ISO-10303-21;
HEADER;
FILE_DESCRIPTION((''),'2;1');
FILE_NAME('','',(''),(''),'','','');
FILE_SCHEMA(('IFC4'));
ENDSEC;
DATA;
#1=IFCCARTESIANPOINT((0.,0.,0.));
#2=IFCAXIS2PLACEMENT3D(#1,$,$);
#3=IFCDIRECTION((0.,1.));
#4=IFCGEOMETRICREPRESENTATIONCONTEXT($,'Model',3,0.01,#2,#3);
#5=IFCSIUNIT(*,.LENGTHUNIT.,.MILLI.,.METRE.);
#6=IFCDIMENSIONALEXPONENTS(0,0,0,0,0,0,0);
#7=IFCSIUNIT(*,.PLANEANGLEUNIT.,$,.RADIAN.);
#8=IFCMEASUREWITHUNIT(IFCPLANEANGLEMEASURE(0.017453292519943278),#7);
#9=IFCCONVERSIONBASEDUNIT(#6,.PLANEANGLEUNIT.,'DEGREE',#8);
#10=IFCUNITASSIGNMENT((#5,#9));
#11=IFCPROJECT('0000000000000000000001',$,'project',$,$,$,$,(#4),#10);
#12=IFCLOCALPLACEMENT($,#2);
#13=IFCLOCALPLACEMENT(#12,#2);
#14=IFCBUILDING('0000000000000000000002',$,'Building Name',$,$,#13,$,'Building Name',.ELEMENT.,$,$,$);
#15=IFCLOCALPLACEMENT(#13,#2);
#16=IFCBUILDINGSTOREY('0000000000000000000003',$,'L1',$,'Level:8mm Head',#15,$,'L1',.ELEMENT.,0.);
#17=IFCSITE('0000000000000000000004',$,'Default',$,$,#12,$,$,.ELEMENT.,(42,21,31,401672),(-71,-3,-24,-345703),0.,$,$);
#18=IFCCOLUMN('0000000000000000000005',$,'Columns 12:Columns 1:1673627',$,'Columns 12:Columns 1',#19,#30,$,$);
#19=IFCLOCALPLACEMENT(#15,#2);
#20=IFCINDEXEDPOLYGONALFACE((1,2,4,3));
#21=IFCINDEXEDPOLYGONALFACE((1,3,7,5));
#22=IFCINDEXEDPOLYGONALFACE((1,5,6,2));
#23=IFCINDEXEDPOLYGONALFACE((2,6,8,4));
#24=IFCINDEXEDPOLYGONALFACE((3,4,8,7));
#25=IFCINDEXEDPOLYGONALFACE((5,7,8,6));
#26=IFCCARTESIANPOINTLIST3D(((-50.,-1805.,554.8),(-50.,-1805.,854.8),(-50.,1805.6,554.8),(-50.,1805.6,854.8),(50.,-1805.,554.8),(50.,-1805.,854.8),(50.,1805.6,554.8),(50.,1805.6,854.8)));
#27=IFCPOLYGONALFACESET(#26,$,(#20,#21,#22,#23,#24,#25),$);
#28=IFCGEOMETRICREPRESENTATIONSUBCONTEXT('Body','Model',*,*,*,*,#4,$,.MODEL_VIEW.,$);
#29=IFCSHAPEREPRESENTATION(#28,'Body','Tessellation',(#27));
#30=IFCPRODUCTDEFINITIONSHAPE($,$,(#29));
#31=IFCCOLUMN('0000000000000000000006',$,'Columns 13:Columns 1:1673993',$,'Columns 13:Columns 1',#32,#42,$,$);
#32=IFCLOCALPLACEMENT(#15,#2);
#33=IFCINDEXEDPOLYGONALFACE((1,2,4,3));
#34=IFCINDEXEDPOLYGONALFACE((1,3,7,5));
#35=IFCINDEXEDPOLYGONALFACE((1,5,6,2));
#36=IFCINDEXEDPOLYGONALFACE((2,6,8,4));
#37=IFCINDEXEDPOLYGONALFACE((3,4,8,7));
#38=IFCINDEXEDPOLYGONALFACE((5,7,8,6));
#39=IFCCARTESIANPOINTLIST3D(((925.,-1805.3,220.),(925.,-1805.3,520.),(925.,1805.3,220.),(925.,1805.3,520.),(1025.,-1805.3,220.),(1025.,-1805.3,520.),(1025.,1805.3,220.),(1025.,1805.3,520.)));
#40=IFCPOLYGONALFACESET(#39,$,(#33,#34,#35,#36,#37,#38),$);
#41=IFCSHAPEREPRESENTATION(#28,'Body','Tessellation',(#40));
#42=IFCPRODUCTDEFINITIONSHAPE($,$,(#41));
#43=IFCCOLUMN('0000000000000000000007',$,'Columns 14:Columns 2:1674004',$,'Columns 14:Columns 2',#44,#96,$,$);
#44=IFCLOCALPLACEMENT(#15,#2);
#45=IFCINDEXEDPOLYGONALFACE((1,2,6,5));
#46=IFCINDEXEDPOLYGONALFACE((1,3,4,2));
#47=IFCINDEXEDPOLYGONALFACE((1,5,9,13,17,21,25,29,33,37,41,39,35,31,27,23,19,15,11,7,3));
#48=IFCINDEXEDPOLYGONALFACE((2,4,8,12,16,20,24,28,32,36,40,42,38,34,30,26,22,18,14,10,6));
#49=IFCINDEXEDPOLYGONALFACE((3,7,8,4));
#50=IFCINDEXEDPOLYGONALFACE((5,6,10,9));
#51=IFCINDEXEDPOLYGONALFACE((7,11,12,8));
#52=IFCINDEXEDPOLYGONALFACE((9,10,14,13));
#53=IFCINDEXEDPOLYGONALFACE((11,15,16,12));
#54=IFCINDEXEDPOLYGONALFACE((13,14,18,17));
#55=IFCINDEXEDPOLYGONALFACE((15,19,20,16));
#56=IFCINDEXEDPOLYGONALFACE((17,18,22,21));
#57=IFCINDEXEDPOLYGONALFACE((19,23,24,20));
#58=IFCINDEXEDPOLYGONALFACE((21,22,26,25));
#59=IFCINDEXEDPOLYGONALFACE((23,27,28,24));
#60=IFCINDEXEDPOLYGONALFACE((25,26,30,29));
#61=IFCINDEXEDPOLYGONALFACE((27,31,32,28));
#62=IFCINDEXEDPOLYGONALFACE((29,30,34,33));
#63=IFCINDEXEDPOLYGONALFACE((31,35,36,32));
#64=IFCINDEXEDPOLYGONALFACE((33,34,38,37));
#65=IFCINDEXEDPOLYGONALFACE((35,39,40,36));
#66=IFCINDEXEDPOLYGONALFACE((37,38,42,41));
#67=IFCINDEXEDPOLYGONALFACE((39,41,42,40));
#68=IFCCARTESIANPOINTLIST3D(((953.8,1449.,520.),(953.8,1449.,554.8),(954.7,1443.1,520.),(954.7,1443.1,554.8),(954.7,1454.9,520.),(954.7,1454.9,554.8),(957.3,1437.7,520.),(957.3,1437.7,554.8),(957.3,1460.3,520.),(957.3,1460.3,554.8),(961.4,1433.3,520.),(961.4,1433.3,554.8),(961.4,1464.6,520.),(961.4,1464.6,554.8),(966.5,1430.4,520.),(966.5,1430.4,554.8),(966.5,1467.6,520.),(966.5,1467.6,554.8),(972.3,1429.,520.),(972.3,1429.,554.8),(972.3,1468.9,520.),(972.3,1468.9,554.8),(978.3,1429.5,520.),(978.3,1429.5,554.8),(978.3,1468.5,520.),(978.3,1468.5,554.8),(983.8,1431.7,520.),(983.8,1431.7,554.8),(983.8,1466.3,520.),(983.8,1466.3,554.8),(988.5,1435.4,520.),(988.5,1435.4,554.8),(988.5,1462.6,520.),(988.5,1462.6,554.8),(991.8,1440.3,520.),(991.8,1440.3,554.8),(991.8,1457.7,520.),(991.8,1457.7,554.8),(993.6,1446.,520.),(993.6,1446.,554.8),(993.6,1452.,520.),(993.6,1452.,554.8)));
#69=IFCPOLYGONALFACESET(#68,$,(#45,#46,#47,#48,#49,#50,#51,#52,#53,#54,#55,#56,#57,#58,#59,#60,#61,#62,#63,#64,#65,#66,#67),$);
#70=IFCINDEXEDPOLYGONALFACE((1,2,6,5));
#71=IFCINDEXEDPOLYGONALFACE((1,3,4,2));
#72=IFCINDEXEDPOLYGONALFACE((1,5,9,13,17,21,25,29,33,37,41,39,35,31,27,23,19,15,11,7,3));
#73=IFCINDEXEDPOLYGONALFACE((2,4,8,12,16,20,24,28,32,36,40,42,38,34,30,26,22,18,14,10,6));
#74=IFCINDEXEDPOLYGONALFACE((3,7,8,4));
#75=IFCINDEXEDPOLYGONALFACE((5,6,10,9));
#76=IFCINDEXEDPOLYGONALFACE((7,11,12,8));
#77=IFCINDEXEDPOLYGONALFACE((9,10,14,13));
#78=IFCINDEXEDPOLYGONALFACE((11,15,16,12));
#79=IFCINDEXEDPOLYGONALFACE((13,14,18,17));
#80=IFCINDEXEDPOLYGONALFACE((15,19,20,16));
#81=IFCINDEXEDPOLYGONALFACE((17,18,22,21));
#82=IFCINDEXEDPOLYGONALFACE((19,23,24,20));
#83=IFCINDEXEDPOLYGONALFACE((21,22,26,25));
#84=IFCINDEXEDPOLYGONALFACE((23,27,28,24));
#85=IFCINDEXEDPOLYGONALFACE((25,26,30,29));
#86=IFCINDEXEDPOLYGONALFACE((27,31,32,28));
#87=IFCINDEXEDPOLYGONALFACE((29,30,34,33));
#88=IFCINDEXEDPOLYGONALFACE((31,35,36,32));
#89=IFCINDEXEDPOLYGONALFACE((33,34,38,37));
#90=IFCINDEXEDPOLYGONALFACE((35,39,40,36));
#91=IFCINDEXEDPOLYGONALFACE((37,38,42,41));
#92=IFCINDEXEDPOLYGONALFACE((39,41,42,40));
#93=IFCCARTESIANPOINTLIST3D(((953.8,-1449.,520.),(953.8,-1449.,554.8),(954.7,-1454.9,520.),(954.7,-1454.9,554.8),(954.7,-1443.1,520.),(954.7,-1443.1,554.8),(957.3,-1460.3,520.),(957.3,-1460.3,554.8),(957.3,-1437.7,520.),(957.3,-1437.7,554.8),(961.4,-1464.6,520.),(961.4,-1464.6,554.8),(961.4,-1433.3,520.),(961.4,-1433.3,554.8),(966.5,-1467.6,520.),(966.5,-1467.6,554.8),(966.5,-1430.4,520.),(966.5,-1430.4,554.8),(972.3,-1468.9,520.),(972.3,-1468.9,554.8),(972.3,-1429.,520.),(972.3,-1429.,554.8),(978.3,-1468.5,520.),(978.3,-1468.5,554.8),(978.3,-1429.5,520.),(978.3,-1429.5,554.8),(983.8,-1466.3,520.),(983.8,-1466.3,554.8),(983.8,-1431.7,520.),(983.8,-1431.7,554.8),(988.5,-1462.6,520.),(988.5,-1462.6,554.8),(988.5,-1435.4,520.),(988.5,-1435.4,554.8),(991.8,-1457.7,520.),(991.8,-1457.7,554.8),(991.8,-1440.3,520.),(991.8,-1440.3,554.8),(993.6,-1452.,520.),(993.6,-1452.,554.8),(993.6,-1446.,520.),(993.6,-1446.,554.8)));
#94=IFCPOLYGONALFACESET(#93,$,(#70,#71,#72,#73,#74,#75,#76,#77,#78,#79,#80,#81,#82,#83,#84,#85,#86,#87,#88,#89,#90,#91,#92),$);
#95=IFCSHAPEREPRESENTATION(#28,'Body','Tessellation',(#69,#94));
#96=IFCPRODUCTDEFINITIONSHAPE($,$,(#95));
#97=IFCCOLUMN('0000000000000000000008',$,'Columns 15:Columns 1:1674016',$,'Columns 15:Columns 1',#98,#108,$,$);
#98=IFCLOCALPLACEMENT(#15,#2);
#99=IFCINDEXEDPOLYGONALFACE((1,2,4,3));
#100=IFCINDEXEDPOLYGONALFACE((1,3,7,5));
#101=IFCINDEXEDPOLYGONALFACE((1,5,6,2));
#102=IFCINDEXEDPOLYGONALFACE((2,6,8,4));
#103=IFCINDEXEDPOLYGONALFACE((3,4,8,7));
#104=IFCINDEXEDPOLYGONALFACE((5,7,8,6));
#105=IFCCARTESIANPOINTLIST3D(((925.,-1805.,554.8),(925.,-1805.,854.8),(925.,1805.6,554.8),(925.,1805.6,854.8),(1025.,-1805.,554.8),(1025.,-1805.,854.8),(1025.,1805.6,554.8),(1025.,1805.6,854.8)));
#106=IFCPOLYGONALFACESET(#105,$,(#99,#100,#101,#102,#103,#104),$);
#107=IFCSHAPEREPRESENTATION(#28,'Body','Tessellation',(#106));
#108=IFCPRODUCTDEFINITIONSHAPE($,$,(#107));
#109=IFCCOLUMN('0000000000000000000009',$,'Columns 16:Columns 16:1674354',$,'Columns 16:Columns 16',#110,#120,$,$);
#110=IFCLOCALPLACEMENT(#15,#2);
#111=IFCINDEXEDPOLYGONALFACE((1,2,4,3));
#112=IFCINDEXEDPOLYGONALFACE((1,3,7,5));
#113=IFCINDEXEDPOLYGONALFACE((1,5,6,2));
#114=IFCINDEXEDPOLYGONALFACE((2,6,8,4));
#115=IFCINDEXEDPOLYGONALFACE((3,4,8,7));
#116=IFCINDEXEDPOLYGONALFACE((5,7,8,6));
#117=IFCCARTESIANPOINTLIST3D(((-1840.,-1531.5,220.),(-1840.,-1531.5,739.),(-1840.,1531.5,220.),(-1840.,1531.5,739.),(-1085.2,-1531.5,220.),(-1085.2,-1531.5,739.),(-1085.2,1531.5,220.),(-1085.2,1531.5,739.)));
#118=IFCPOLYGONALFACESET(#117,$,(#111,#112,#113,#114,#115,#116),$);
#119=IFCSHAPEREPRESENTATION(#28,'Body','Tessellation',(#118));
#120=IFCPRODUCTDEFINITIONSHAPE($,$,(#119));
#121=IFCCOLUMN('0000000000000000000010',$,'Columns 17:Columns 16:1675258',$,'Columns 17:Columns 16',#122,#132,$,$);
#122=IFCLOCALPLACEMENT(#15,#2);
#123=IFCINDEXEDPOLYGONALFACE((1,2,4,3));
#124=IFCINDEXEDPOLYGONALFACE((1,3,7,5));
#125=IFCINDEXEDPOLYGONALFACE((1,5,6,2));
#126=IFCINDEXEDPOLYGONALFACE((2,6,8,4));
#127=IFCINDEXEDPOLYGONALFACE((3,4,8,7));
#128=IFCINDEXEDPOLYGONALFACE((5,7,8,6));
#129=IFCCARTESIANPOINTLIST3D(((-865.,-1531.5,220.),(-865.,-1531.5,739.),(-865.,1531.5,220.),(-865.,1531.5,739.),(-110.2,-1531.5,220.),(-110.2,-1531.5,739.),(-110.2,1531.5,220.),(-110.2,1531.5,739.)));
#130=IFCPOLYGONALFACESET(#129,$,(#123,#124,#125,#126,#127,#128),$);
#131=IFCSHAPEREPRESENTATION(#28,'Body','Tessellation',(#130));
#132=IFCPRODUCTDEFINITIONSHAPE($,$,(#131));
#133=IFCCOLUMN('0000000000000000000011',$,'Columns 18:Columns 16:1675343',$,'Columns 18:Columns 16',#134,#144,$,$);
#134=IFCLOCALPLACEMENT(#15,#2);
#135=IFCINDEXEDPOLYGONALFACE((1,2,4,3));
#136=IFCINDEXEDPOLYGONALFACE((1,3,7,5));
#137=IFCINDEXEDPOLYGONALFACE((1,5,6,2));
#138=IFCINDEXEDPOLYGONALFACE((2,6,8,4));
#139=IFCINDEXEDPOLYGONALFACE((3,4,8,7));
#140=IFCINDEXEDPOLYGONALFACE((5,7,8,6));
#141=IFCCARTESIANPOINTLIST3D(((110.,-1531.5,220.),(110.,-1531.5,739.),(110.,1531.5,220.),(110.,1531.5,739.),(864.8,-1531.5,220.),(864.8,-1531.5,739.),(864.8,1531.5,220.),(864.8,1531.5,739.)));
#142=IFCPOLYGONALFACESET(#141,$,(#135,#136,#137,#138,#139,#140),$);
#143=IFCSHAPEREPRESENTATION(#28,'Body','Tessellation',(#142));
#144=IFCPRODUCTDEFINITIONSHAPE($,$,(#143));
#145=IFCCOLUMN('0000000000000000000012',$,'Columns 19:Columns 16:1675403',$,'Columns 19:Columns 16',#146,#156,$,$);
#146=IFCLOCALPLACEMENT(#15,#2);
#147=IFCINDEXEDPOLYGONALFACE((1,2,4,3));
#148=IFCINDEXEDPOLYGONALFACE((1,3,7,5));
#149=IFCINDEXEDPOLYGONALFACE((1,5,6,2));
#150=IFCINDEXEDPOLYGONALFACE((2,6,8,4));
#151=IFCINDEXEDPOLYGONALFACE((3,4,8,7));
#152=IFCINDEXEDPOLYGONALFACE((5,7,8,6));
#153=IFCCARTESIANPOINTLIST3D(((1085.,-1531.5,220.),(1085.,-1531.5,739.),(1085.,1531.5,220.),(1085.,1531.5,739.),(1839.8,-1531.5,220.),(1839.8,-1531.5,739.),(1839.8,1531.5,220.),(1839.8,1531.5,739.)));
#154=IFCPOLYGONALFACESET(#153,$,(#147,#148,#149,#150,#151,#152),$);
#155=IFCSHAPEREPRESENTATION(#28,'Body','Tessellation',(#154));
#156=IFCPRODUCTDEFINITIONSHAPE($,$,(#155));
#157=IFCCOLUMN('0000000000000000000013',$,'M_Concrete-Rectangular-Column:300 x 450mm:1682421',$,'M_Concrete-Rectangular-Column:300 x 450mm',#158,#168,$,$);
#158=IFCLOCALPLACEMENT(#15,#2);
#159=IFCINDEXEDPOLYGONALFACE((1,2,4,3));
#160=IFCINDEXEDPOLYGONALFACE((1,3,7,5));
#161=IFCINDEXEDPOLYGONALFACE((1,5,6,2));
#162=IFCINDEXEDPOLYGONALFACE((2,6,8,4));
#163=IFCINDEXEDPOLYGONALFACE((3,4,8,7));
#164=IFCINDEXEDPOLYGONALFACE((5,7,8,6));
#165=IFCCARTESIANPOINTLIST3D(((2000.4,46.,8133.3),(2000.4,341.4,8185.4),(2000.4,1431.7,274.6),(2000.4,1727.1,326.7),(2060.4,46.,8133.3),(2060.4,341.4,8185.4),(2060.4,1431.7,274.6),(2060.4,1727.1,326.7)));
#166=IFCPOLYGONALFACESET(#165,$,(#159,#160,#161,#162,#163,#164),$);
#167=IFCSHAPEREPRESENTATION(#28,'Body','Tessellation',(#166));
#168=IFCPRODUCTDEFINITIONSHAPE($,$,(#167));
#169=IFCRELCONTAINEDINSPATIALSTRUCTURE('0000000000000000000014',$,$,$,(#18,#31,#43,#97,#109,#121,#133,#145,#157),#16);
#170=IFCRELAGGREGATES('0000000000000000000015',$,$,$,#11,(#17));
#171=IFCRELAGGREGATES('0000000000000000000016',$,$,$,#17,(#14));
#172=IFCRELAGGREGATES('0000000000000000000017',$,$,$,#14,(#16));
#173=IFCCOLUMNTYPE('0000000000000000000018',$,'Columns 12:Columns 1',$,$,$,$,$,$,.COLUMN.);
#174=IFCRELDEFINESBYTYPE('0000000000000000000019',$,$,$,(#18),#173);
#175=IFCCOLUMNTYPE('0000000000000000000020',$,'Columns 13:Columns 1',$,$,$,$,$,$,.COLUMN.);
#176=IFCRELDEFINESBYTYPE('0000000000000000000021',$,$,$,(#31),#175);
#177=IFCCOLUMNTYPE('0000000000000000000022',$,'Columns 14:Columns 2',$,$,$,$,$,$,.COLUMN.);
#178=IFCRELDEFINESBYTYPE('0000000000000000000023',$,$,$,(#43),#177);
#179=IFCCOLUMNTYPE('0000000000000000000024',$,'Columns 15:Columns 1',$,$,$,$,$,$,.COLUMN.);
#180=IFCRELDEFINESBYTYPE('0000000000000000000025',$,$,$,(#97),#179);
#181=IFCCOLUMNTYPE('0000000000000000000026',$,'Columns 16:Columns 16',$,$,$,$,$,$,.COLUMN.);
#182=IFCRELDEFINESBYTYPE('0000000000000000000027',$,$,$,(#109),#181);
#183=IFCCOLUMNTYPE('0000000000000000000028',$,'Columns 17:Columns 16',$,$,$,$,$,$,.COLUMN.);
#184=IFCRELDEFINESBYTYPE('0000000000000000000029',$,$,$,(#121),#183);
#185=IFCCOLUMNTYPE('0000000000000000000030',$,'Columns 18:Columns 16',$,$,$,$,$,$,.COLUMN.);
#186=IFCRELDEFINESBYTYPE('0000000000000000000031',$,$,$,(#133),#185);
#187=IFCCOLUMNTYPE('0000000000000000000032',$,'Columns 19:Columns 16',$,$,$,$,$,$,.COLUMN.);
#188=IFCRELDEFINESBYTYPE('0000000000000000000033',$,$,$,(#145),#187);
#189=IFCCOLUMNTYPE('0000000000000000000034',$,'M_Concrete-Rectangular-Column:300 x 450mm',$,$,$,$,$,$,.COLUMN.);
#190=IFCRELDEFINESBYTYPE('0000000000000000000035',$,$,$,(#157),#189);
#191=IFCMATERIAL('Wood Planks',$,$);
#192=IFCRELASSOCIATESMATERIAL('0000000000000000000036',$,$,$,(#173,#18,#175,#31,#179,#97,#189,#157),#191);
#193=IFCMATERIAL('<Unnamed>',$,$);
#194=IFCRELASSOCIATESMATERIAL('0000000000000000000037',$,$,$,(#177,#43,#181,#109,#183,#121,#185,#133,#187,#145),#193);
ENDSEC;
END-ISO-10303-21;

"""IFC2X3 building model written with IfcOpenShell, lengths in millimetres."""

from ifc_helpers import new_model, entity, si_unit, converted_unit, direction, frame, frame_2d, origin, origin_2d_with_axis, place, context, subcontext, project, spatial, rectangle, circle, extrude, source, transform, mapped, material, type_object, type_shapes, element, save


model = new_model("IFC2X3")

# Units and contexts
model_context = context("Model", 3, precision=0.01, world=origin(), true_north=direction((0.0, 1.0)))
body_context = subcontext(model_context, "Body", "Model", "MODEL_VIEW")
ifc_project = project(units=[si_unit("LENGTHUNIT", "METRE", prefix="MILLI"), converted_unit("PLANEANGLEUNIT", "DEGREE", entity("IfcPlaneAngleMeasure", 0.017453292519943278), si_unit("PLANEANGLEUNIT", "RADIAN"), dimensions=[0, 0, 0, 0, 0, 0, 0])], contexts=[model_context])

# Site, building, storey
site_placement = place(None, origin())
site = spatial("IfcSite", under=ifc_project, at=site_placement, Name="Default", CompositionType="ELEMENT", RefLatitude=(42, 21, 31, 401672), RefLongitude=(-71, -3, -24, -345703), RefElevation=0.0)
building_placement = place(site_placement, origin())
building = spatial("IfcBuilding", under=site, at=building_placement, Name="Building Name", LongName="Building Name", CompositionType="ELEMENT")
storey_placement = place(building_placement, origin())
storey = spatial("IfcBuildingStorey", under=building, at=storey_placement, Name="L1", ObjectType="Level:8mm Head", LongName="L1", CompositionType="ELEMENT", Elevation=0.0)

# Columns
ifc_material_1 = material(Name="<Unnamed>")
ifc_material_2 = material(Name="Wood Planks")
column_type_1 = type_object("IfcColumnType", Name="Columns 12:Columns 1", PredefinedType="COLUMN", material=ifc_material_2)
shared_shape_1 = source(origin(), body_context, "Body", "SweptSolid", [
    extrude(rectangle(XDim=3610.6, YDim=100.0, at=origin_2d_with_axis()), frame((0.0, 0.3, 554.8), z_axis=(0.0, 0.0, 1.0), x_axis=(0.0, -1.0, 0.0)), (0.0, 0.0, 1.0), 300.0),
])
type_shapes(column_type_1, [shared_shape_1])
column_1_placement = place(storey_placement, origin())
element("IfcColumn", 1, at=column_1_placement, inside=storey, type_object=column_type_1, material=ifc_material_2, Name="Columns 12:Columns 1:1673627", ObjectType="Columns 12:Columns 1", context=body_context, shape_type="MappedRepresentation", body=[
    mapped(shared_shape_1, transform((0.0, 0.0, 0.0), scale=1.0)),
])
column_type_2 = type_object("IfcColumnType", Name="Columns 13:Columns 1", PredefinedType="COLUMN", material=ifc_material_2)
shared_shape_2 = source(origin(), body_context, "Body", "SweptSolid", [
    extrude(rectangle(XDim=3610.6, YDim=100.0, at=frame_2d((0.0, 0.0), x_axis=(1.0, 0.0))), frame((975.0, 0.0, 220.0), z_axis=(0.0, 0.0, 1.0), x_axis=(0.0, -1.0, 0.0)), (0.0, 0.0, 1.0), 300.0),
])
type_shapes(column_type_2, [shared_shape_2])
column_2_placement = place(storey_placement, origin())
element("IfcColumn", 2, at=column_2_placement, inside=storey, type_object=column_type_2, material=ifc_material_2, Name="Columns 13:Columns 1:1673993", ObjectType="Columns 13:Columns 1", context=body_context, shape_type="MappedRepresentation", body=[
    mapped(shared_shape_2, transform((0.0, 0.0, 0.0), scale=1.0)),
])
column_type_3 = type_object("IfcColumnType", Name="Columns 14:Columns 2", PredefinedType="COLUMN", material=ifc_material_1)
shared_shape_3 = source(origin(), body_context, "Body", "SweptSolid", [
    extrude(circle(Radius=20.0, at=origin_2d_with_axis()), frame((973.8, 1449.0, 520.0), z_axis=(0.0, 0.0, 1.0), x_axis=(-1.0, 0.0, 0.0)), (0.0, 0.0, 1.0), 34.8),
    extrude(circle(Radius=20.0, at=frame_2d((0.0, 0.0), x_axis=(1.0, 0.0))), frame((973.8, -1449.0, 520.0), z_axis=(0.0, 0.0, 1.0), x_axis=(-1.0, 0.0, 0.0)), (0.0, 0.0, 1.0), 34.8),
])
type_shapes(column_type_3, [shared_shape_3])
column_3_placement = place(storey_placement, origin())
element("IfcColumn", 3, at=column_3_placement, inside=storey, type_object=column_type_3, material=ifc_material_1, Name="Columns 14:Columns 2:1674004", ObjectType="Columns 14:Columns 2", context=body_context, shape_type="MappedRepresentation", body=[
    mapped(shared_shape_3, transform((0.0, 0.0, 0.0), scale=1.0)),
])
column_type_4 = type_object("IfcColumnType", Name="Columns 15:Columns 1", PredefinedType="COLUMN", material=ifc_material_2)
shared_shape_4 = source(origin(), body_context, "Body", "SweptSolid", [
    extrude(rectangle(XDim=3610.6, YDim=100.0, at=frame_2d((0.0, 0.0), x_axis=(1.0, 0.0))), frame((975.0, 0.3, 554.8), z_axis=(0.0, 0.0, 1.0), x_axis=(0.0, -1.0, 0.0)), (0.0, 0.0, 1.0), 300.0),
])
type_shapes(column_type_4, [shared_shape_4])
column_4_placement = place(storey_placement, origin())
element("IfcColumn", 4, at=column_4_placement, inside=storey, type_object=column_type_4, material=ifc_material_2, Name="Columns 15:Columns 1:1674016", ObjectType="Columns 15:Columns 1", context=body_context, shape_type="MappedRepresentation", body=[
    mapped(shared_shape_4, transform((0.0, 0.0, 0.0), scale=1.0)),
])
column_type_5 = type_object("IfcColumnType", Name="Columns 16:Columns 16", PredefinedType="COLUMN", material=ifc_material_1)
shared_shape_5 = source(origin(), body_context, "Body", "SweptSolid", [
    extrude(rectangle(XDim=3063.1, YDim=754.8, at=frame_2d((0.0, 0.0), x_axis=(1.0, 0.0))), frame((-1462.6, 0.0, 220.0), z_axis=(0.0, 0.0, 1.0), x_axis=(0.0, 1.0, 0.0)), (0.0, 0.0, 1.0), 519.0),
])
type_shapes(column_type_5, [shared_shape_5])
column_5_placement = place(storey_placement, origin())
element("IfcColumn", 5, at=column_5_placement, inside=storey, type_object=column_type_5, material=ifc_material_1, Name="Columns 16:Columns 16:1674354", ObjectType="Columns 16:Columns 16", context=body_context, shape_type="MappedRepresentation", body=[
    mapped(shared_shape_5, transform((0.0, 0.0, 0.0), scale=1.0)),
])
column_type_6 = type_object("IfcColumnType", Name="Columns 17:Columns 16", PredefinedType="COLUMN", material=ifc_material_1)
shared_shape_6 = source(origin(), body_context, "Body", "SweptSolid", [
    extrude(rectangle(XDim=3063.1, YDim=754.8, at=origin_2d_with_axis()), frame((-487.6, 0.0, 220.0), z_axis=(0.0, 0.0, 1.0), x_axis=(0.0, 1.0, 0.0)), (0.0, 0.0, 1.0), 519.0),
])
type_shapes(column_type_6, [shared_shape_6])
column_6_placement = place(storey_placement, origin())
element("IfcColumn", 6, at=column_6_placement, inside=storey, type_object=column_type_6, material=ifc_material_1, Name="Columns 17:Columns 16:1675258", ObjectType="Columns 17:Columns 16", context=body_context, shape_type="MappedRepresentation", body=[
    mapped(shared_shape_6, transform((0.0, 0.0, 0.0), scale=1.0)),
])
column_type_7 = type_object("IfcColumnType", Name="Columns 18:Columns 16", PredefinedType="COLUMN", material=ifc_material_1)
shared_shape_7 = source(origin(), body_context, "Body", "SweptSolid", [
    extrude(rectangle(XDim=3063.1, YDim=754.8, at=origin_2d_with_axis()), frame((487.4, 0.0, 220.0), z_axis=(0.0, 0.0, 1.0), x_axis=(0.0, 1.0, 0.0)), (0.0, 0.0, 1.0), 519.0),
])
type_shapes(column_type_7, [shared_shape_7])
column_7_placement = place(storey_placement, origin())
element("IfcColumn", 7, at=column_7_placement, inside=storey, type_object=column_type_7, material=ifc_material_1, Name="Columns 18:Columns 16:1675343", ObjectType="Columns 18:Columns 16", context=body_context, shape_type="MappedRepresentation", body=[
    mapped(shared_shape_7, transform((0.0, 0.0, 0.0), scale=1.0)),
])
column_type_8 = type_object("IfcColumnType", Name="Columns 19:Columns 16", PredefinedType="COLUMN", material=ifc_material_1)
shared_shape_8 = source(origin(), body_context, "Body", "SweptSolid", [
    extrude(rectangle(XDim=3063.1, YDim=754.8, at=origin_2d_with_axis()), frame((1462.4, 0.0, 220.0), z_axis=(0.0, 0.0, 1.0), x_axis=(0.0, 1.0, 0.0)), (0.0, 0.0, 1.0), 519.0),
])
type_shapes(column_type_8, [shared_shape_8])
column_8_placement = place(storey_placement, origin())
element("IfcColumn", 8, at=column_8_placement, inside=storey, type_object=column_type_8, material=ifc_material_1, Name="Columns 19:Columns 16:1675403", ObjectType="Columns 19:Columns 16", context=body_context, shape_type="MappedRepresentation", body=[
    mapped(shared_shape_8, transform((0.0, 0.0, 0.0), scale=1.0)),
])
column_type_9 = type_object("IfcColumnType", Name="M_Concrete-Rectangular-Column:300 x 450mm", PredefinedType="COLUMN", material=ifc_material_2)
shared_shape_9 = source(origin(), body_context, "Body", "SweptSolid", [
    extrude(rectangle(XDim=300.0, YDim=60.0, at=frame_2d((0.0, 0.0), x_axis=(1.0, 0.0))), frame((2030.4, 1579.4, 300.6), z_axis=(0.0, -0.173648, 0.984808), x_axis=(0.0, -0.984808, -0.173648)), (0.0, 0.0, 1.0), 7980.0),
])
type_shapes(column_type_9, [shared_shape_9])
column_9_placement = place(storey_placement, origin())
element("IfcColumn", 9, at=column_9_placement, inside=storey, type_object=column_type_9, material=ifc_material_2, Name="M_Concrete-Rectangular-Column:300 x 450mm:1682421", ObjectType="M_Concrete-Rectangular-Column:300 x 450mm", context=body_context, shape_type="MappedRepresentation", body=[
    mapped(shared_shape_9, transform((0.0, 0.0, 0.0), scale=1.0)),
])

save(model, "model.ifc")
